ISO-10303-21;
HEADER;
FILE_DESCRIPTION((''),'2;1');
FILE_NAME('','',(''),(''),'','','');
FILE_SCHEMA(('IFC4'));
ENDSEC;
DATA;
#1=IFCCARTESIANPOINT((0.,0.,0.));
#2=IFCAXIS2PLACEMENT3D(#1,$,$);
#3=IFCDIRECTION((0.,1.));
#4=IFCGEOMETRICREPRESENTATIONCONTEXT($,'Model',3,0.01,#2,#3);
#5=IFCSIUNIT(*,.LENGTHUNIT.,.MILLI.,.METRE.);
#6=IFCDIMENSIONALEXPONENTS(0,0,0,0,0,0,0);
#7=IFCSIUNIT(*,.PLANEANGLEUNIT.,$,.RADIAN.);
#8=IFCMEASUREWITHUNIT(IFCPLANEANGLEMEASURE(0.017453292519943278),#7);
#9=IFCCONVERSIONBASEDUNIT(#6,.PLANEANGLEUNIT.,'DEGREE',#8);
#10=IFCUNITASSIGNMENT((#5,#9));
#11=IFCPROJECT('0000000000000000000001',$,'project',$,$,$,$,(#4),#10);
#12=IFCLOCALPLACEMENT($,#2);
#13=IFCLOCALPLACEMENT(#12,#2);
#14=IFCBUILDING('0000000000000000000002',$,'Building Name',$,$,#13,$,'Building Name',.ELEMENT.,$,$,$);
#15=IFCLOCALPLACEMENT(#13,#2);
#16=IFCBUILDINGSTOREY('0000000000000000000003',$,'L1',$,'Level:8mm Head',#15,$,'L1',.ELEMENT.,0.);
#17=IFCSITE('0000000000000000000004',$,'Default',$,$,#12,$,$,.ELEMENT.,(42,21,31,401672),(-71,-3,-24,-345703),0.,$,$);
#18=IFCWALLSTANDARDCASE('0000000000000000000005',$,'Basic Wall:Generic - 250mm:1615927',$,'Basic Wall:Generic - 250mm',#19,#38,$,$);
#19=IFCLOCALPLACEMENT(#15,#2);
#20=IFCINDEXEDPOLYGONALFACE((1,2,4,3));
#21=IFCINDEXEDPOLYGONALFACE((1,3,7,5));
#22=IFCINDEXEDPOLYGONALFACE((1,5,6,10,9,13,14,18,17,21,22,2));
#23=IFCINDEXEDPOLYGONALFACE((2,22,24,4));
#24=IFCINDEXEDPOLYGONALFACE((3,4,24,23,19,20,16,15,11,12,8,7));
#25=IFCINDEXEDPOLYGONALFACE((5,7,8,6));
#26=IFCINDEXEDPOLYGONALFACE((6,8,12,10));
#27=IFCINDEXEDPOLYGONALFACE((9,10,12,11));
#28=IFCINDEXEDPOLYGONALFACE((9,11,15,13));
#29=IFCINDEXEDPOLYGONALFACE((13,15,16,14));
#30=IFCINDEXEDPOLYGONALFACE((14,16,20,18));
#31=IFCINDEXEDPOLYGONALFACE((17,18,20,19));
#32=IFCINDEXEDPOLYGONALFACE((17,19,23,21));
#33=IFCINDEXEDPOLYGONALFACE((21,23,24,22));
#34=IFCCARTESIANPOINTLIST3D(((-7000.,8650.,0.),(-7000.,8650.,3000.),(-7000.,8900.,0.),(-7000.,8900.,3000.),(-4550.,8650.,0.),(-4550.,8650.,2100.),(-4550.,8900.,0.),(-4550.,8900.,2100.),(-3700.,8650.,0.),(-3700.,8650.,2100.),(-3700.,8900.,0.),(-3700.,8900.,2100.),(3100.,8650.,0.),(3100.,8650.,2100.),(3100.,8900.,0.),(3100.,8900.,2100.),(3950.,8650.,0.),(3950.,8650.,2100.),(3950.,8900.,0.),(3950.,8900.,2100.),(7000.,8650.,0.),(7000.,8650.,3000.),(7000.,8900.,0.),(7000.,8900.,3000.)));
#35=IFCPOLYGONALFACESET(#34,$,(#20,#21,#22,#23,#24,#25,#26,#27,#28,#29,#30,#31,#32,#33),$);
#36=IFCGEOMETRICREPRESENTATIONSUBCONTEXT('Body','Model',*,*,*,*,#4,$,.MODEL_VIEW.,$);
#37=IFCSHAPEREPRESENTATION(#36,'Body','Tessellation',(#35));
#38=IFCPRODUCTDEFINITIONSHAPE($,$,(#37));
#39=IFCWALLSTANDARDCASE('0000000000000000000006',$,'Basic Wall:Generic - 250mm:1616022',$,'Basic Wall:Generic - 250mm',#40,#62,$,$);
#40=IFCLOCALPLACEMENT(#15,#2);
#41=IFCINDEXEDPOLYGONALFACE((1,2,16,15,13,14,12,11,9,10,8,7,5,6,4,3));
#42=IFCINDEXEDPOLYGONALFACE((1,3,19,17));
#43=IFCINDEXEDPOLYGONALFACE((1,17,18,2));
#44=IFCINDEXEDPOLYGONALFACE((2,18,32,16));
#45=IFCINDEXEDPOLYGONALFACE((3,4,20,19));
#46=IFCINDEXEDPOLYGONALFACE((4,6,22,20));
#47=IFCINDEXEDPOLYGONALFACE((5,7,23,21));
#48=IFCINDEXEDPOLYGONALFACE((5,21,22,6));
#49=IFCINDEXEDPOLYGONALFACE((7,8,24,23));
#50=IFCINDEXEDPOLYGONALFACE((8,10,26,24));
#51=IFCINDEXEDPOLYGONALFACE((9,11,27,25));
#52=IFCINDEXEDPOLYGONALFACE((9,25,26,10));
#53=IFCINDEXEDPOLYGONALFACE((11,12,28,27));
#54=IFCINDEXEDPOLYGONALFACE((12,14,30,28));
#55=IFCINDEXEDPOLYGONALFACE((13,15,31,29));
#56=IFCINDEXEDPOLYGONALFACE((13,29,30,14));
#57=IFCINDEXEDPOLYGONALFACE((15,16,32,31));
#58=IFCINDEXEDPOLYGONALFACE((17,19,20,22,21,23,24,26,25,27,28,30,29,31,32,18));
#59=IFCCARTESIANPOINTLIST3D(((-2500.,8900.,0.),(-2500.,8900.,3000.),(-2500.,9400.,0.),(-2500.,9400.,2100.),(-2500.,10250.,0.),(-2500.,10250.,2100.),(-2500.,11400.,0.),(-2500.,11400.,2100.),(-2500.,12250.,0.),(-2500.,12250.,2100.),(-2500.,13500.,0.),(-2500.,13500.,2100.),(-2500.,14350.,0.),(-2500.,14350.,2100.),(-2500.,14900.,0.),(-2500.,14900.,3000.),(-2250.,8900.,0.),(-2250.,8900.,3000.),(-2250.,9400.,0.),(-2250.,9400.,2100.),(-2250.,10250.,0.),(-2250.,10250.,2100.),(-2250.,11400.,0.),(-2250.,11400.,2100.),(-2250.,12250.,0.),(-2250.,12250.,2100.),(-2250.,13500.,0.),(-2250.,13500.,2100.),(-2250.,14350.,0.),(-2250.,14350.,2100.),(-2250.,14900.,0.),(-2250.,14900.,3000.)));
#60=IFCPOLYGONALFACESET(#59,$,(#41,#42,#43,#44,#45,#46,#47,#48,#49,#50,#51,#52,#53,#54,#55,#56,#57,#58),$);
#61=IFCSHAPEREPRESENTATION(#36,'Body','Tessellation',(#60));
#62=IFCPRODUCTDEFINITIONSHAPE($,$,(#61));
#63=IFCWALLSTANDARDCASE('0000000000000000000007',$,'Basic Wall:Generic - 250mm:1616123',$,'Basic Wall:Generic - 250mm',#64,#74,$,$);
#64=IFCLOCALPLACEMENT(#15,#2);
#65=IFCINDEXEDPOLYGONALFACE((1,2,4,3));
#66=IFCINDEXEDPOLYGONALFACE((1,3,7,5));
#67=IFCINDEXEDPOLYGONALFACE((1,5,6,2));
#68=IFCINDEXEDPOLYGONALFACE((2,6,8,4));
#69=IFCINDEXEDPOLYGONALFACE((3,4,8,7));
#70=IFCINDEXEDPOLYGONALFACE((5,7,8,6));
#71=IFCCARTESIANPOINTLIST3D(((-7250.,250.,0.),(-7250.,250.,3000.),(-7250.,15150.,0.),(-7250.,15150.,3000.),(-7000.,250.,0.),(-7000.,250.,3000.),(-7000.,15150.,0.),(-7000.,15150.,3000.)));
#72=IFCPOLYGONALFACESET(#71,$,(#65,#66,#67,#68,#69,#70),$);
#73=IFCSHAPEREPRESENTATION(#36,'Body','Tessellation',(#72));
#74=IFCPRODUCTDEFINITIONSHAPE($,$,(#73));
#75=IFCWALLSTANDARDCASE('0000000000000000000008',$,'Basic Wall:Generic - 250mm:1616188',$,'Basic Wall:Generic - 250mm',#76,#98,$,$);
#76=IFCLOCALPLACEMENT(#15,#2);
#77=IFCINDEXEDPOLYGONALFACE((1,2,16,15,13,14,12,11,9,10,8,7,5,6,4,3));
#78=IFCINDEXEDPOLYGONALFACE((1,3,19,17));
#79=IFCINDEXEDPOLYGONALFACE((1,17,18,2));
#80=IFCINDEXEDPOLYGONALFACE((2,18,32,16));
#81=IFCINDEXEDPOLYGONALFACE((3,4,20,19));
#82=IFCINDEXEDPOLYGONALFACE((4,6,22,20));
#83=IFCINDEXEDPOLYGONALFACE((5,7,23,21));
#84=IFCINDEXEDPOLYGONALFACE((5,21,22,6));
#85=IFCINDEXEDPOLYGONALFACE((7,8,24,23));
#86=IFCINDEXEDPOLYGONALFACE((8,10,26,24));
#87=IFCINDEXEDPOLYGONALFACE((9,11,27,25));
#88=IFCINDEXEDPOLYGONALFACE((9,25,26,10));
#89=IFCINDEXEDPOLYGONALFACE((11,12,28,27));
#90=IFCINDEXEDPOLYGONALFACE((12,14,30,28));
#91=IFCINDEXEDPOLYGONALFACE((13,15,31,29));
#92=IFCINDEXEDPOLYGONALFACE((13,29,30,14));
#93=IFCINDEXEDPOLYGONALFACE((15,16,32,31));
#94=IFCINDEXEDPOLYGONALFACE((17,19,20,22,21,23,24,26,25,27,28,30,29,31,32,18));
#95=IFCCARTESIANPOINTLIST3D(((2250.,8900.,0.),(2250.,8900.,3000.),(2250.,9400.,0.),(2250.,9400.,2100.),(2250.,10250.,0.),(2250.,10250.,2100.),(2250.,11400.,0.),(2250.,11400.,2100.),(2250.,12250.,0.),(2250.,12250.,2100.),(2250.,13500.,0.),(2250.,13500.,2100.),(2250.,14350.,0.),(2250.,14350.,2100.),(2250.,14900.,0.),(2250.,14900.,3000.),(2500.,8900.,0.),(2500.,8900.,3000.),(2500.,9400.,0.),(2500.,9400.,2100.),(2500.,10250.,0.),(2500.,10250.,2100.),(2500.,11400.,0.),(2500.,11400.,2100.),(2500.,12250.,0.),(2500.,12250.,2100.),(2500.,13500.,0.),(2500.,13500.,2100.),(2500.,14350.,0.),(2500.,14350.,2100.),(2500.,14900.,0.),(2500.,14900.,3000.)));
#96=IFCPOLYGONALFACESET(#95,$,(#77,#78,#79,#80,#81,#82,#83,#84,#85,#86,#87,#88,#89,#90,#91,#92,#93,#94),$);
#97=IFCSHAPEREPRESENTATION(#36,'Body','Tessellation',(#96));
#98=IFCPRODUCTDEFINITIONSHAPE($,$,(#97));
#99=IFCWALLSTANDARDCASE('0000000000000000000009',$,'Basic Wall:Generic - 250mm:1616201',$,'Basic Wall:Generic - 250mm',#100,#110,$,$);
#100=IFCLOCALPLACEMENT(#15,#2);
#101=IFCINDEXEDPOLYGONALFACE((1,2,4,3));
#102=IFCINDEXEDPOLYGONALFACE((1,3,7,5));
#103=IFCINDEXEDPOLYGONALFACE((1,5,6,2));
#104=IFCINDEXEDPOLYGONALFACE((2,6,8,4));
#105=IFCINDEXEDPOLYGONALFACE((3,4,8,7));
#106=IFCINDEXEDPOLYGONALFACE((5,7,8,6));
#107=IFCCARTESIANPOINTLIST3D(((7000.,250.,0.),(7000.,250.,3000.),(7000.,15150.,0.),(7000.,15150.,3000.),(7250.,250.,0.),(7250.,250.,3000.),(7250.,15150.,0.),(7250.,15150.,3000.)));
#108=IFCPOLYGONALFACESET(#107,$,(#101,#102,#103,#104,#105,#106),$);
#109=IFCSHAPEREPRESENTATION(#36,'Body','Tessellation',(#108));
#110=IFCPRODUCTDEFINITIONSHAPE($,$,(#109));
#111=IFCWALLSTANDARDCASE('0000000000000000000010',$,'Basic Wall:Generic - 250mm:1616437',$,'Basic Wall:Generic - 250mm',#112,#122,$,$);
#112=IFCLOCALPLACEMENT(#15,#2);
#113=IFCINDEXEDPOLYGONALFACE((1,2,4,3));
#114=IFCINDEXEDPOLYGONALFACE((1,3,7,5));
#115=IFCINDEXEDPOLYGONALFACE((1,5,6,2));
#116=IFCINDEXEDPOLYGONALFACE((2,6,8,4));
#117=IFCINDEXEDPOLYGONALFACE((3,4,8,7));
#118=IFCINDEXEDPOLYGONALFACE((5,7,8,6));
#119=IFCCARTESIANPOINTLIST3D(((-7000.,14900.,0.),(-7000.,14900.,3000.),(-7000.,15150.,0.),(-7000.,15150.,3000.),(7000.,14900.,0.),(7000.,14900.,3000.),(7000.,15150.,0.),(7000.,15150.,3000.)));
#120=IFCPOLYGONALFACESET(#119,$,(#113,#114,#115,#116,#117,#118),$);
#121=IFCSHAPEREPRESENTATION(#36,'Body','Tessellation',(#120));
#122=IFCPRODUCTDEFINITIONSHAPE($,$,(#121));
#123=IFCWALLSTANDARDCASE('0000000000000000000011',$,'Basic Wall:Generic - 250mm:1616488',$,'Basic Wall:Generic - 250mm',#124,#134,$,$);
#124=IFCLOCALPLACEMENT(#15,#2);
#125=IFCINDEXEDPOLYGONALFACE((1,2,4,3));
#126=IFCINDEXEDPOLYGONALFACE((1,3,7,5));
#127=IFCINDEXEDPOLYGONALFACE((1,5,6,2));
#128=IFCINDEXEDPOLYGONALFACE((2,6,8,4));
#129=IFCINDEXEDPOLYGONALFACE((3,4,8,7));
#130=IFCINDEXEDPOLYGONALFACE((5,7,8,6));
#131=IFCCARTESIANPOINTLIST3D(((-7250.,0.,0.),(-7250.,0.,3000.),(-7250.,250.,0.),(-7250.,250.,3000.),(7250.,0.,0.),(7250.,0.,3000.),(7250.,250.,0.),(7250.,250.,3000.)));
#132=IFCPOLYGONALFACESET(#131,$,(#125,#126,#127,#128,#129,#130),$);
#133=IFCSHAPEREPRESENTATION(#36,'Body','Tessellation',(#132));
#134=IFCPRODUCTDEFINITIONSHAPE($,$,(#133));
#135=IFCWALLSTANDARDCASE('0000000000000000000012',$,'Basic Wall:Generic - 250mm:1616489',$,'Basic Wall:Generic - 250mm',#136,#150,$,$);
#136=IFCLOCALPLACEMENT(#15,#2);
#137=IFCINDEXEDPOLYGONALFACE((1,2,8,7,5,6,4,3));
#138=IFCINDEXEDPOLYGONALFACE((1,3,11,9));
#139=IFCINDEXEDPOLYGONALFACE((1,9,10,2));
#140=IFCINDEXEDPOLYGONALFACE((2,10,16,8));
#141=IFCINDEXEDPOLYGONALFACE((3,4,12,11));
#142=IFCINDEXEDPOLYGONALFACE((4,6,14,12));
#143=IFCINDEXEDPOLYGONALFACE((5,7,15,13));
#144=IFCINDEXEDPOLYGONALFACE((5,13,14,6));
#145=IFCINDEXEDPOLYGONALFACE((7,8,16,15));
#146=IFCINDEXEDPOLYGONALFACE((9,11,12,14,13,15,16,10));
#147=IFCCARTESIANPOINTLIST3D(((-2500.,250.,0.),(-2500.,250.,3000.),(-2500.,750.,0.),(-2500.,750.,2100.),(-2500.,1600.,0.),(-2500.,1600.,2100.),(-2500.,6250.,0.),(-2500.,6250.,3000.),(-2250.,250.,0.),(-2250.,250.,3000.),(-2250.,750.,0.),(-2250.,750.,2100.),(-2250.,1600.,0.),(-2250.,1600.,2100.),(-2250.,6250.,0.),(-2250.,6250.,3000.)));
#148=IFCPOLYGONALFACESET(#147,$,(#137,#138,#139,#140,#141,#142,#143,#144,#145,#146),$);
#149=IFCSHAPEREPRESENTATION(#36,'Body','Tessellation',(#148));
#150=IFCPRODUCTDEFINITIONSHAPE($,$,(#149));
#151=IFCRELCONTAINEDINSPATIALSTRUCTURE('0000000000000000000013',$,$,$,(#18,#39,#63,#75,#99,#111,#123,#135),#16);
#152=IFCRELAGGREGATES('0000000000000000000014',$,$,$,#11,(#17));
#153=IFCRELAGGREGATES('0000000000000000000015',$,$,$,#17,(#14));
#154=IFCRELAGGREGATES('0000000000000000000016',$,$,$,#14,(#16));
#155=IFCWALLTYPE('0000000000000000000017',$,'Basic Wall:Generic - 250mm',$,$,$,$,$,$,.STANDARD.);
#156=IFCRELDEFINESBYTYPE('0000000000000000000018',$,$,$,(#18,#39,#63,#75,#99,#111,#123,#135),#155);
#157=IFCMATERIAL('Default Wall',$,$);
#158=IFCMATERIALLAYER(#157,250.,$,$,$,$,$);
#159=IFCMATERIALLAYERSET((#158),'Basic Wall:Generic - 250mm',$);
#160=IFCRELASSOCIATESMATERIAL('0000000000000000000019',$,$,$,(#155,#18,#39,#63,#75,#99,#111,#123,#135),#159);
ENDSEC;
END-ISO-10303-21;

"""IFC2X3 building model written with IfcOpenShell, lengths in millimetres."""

from ifc_helpers import new_model, entity, si_unit, converted_unit, direction, frame, frame_2d, origin, place, context, subcontext, project, spatial, rectangle, extrude, material, layer, layer_set, layer_usage, type_object, element, save


model = new_model("IFC2X3")

# Units and contexts
model_context = context("Model", 3, precision=0.01, world=origin(), true_north=direction((0.0, 1.0)))
body_context = subcontext(model_context, "Body", "Model", "MODEL_VIEW")
ifc_project = project(units=[si_unit("LENGTHUNIT", "METRE", prefix="MILLI"), converted_unit("PLANEANGLEUNIT", "DEGREE", entity("IfcPlaneAngleMeasure", 0.017453292519943278), si_unit("PLANEANGLEUNIT", "RADIAN"), dimensions=[0, 0, 0, 0, 0, 0, 0])], contexts=[model_context])

# Site, building, storey
site_placement = place(None, origin())
site = spatial("IfcSite", under=ifc_project, at=site_placement, Name="Default", CompositionType="ELEMENT", RefLatitude=(42, 21, 31, 401672), RefLongitude=(-71, -3, -24, -345703), RefElevation=0.0)
building_placement = place(site_placement, origin())
building = spatial("IfcBuilding", under=site, at=building_placement, Name="Building Name", LongName="Building Name", CompositionType="ELEMENT")
storey_placement = place(building_placement, origin())
storey = spatial("IfcBuildingStorey", under=building, at=storey_placement, Name="L1", ObjectType="Level:8mm Head", LongName="L1", CompositionType="ELEMENT", Elevation=0.0)

# Walls, openings
ifc_material = material(Name="Default Wall")
ifc_layer_1 = layer(ifc_material, 250.0)
ifc_layer_set_1 = layer_set([ifc_layer_1], Name="Basic Wall:Generic - 250mm")
ifc_layer_usage_1 = layer_usage(ifc_layer_set_1, "AXIS2", "NEGATIVE", 125.0)
wall_type_1 = type_object("IfcWallType", Name="Basic Wall:Generic - 250mm", PredefinedType="STANDARD", material=ifc_layer_set_1)
wall_1_placement = place(storey_placement, frame((-7000.0, 8775.0, 0.0)))
wall_1 = element("IfcWallStandardCase", 1, at=wall_1_placement, inside=storey, type_object=wall_type_1, material=ifc_layer_usage_1, Name="Basic Wall:Generic - 250mm:1615927", ObjectType="Basic Wall:Generic - 250mm", context=body_context, shape_type="SweptSolid", body=[
    extrude(rectangle(XDim=14000.0, YDim=250.0, at=frame_2d((7000.0, 0.0), x_axis=(1.0, 0.0))), origin(), (0.0, 0.0, 1.0), 3000.0),
])
opening_1_placement = place(wall_1_placement, frame((2450.0, -125.0, 0.0)))
element("IfcOpeningElement", 2, at=opening_1_placement, cuts=wall_1, ObjectType="Opening", context=body_context, shape_type="SweptSolid", body=[
    extrude(rectangle(XDim=2100.0, YDim=850.0, at=frame_2d((1050.0, 425.0), x_axis=(1.0, 0.0))), frame((0.0, 0.0, 0.0), z_axis=(0.0, 1.0, 0.0), x_axis=(0.0, 0.0, 1.0)), (0.0, 0.0, 1.0), 250.0),
])
opening_2_placement = place(wall_1_placement, frame((10100.0, -125.0, 0.0)))
element("IfcOpeningElement", 3, at=opening_2_placement, cuts=wall_1, ObjectType="Opening", context=body_context, shape_type="SweptSolid", body=[
    extrude(rectangle(XDim=2100.0, YDim=850.0, at=frame_2d((1050.0, 425.0), x_axis=(1.0, 0.0))), frame((0.0, 0.0, 0.0), z_axis=(0.0, 1.0, 0.0), x_axis=(0.0, 0.0, 1.0)), (0.0, 0.0, 1.0), 250.0),
])
ifc_layer_usage_2 = layer_usage(ifc_layer_set_1, "AXIS2", "NEGATIVE", 125.0)
wall_2_placement = place(storey_placement, frame((-2375.0, 8900.0, 0.0), z_axis=(0.0, 0.0, 1.0), x_axis=(0.0, 1.0, 0.0)))
wall_2 = element("IfcWallStandardCase", 4, at=wall_2_placement, inside=storey, type_object=wall_type_1, material=ifc_layer_usage_2, Name="Basic Wall:Generic - 250mm:1616022", ObjectType="Basic Wall:Generic - 250mm", context=body_context, shape_type="SweptSolid", body=[
    extrude(rectangle(XDim=6000.0, YDim=250.0, at=frame_2d((3000.0, 0.0), x_axis=(1.0, 0.0))), origin(), (0.0, 0.0, 1.0), 3000.0),
])
opening_3_placement = place(wall_2_placement, frame((1350.0, 125.0, 0.0)))
element("IfcOpeningElement", 5, at=opening_3_placement, cuts=wall_2, ObjectType="Opening", context=body_context, shape_type="SweptSolid", body=[
    extrude(rectangle(XDim=2100.0, YDim=850.0, at=frame_2d((1050.0, 425.0), x_axis=(1.0, 0.0))), frame((0.0, 0.0, 0.0), z_axis=(0.0, -1.0, 0.0), x_axis=(0.0, 0.0, 1.0)), (0.0, 0.0, 1.0), 250.0),
])
opening_4_placement = place(wall_2_placement, frame((3350.0, 125.0, 0.0)))
element("IfcOpeningElement", 6, at=opening_4_placement, cuts=wall_2, ObjectType="Opening", context=body_context, shape_type="SweptSolid", body=[
    extrude(rectangle(XDim=2100.0, YDim=850.0, at=frame_2d((1050.0, 425.0), x_axis=(1.0, 0.0))), frame((0.0, 0.0, 0.0), z_axis=(0.0, -1.0, 0.0), x_axis=(0.0, 0.0, 1.0)), (0.0, 0.0, 1.0), 250.0),
])
opening_5_placement = place(wall_2_placement, frame((5450.0, 125.0, 0.0)))
element("IfcOpeningElement", 7, at=opening_5_placement, cuts=wall_2, ObjectType="Opening", context=body_context, shape_type="SweptSolid", body=[
    extrude(rectangle(XDim=2100.0, YDim=850.0, at=frame_2d((1050.0, 425.0), x_axis=(1.0, 0.0))), frame((0.0, 0.0, 0.0), z_axis=(0.0, -1.0, 0.0), x_axis=(0.0, 0.0, 1.0)), (0.0, 0.0, 1.0), 250.0),
])

# Wall
ifc_layer_usage_3 = layer_usage(ifc_layer_set_1, "AXIS2", "NEGATIVE", 125.0)
wall_3_placement = place(storey_placement, frame((-7125.0, 15150.0, 0.0), z_axis=(0.0, 0.0, 1.0), x_axis=(0.0, -1.0, 0.0)))
element("IfcWallStandardCase", 8, at=wall_3_placement, inside=storey, type_object=wall_type_1, material=ifc_layer_usage_3, Name="Basic Wall:Generic - 250mm:1616123", ObjectType="Basic Wall:Generic - 250mm", context=body_context, shape_type="SweptSolid", body=[
    extrude(rectangle(XDim=14900.0, YDim=250.0, at=frame_2d((7450.0, 0.0), x_axis=(-1.0, 0.0))), origin(), (0.0, 0.0, 1.0), 3000.0),
])

# Wall, openings
ifc_layer_usage_4 = layer_usage(ifc_layer_set_1, "AXIS2", "NEGATIVE", 125.0)
wall_4_placement = place(storey_placement, frame((2375.0, 8900.0, 0.0), z_axis=(0.0, 0.0, 1.0), x_axis=(0.0, 1.0, 0.0)))
wall_4 = element("IfcWallStandardCase", 9, at=wall_4_placement, inside=storey, type_object=wall_type_1, material=ifc_layer_usage_4, Name="Basic Wall:Generic - 250mm:1616188", ObjectType="Basic Wall:Generic - 250mm", context=body_context, shape_type="SweptSolid", body=[
    extrude(rectangle(XDim=6000.0, YDim=250.0, at=frame_2d((3000.0, 0.0), x_axis=(-1.0, 0.0))), origin(), (0.0, 0.0, 1.0), 3000.0),
])
opening_6_placement = place(wall_4_placement, frame((500.0, -125.0, 0.0)))
element("IfcOpeningElement", 10, at=opening_6_placement, cuts=wall_4, ObjectType="Opening", context=body_context, shape_type="SweptSolid", body=[
    extrude(rectangle(XDim=2100.0, YDim=850.0, at=frame_2d((1050.0, 425.0), x_axis=(1.0, 0.0))), frame((0.0, 0.0, 0.0), z_axis=(0.0, 1.0, 0.0), x_axis=(0.0, 0.0, 1.0)), (0.0, 0.0, 1.0), 250.0),
])
opening_7_placement = place(wall_4_placement, frame((2500.0, -125.0, 0.0)))
element("IfcOpeningElement", 11, at=opening_7_placement, cuts=wall_4, ObjectType="Opening", context=body_context, shape_type="SweptSolid", body=[
    extrude(rectangle(XDim=2100.0, YDim=850.0, at=frame_2d((1050.0, 425.0), x_axis=(1.0, 0.0))), frame((0.0, 0.0, 0.0), z_axis=(0.0, 1.0, 0.0), x_axis=(0.0, 0.0, 1.0)), (0.0, 0.0, 1.0), 250.0),
])
opening_8_placement = place(wall_4_placement, frame((4600.0, -125.0, 0.0)))
element("IfcOpeningElement", 12, at=opening_8_placement, cuts=wall_4, ObjectType="Opening", context=body_context, shape_type="SweptSolid", body=[
    extrude(rectangle(XDim=2100.0, YDim=850.0, at=frame_2d((1050.0, 425.0), x_axis=(1.0, 0.0))), frame((0.0, 0.0, 0.0), z_axis=(0.0, 1.0, 0.0), x_axis=(0.0, 0.0, 1.0)), (0.0, 0.0, 1.0), 250.0),
])

# Walls
ifc_layer_usage_5 = layer_usage(ifc_layer_set_1, "AXIS2", "NEGATIVE", 125.0)
wall_5_placement = place(storey_placement, frame((7125.0, 250.0, 0.0), z_axis=(0.0, 0.0, 1.0), x_axis=(0.0, 1.0, 0.0)))
element("IfcWallStandardCase", 13, at=wall_5_placement, inside=storey, type_object=wall_type_1, material=ifc_layer_usage_5, Name="Basic Wall:Generic - 250mm:1616201", ObjectType="Basic Wall:Generic - 250mm", context=body_context, shape_type="SweptSolid", body=[
    extrude(rectangle(XDim=14900.0, YDim=250.0, at=frame_2d((7450.0, 0.0), x_axis=(-1.0, 0.0))), origin(), (0.0, 0.0, 1.0), 3000.0),
])
ifc_layer_usage_6 = layer_usage(ifc_layer_set_1, "AXIS2", "NEGATIVE", 125.0)
wall_6_placement = place(storey_placement, frame((-7000.0, 15025.0, 0.0)))
element("IfcWallStandardCase", 14, at=wall_6_placement, inside=storey, type_object=wall_type_1, material=ifc_layer_usage_6, Name="Basic Wall:Generic - 250mm:1616437", ObjectType="Basic Wall:Generic - 250mm", context=body_context, shape_type="SweptSolid", body=[
    extrude(rectangle(XDim=14000.0, YDim=250.0, at=frame_2d((7000.0, 0.0), x_axis=(-1.0, 0.0))), origin(), (0.0, 0.0, 1.0), 3000.0),
])
ifc_layer_usage_7 = layer_usage(ifc_layer_set_1, "AXIS2", "NEGATIVE", 125.0)
wall_7_placement = place(storey_placement, frame((-7250.0, 125.0, 0.0)))
element("IfcWallStandardCase", 15, at=wall_7_placement, inside=storey, type_object=wall_type_1, material=ifc_layer_usage_7, Name="Basic Wall:Generic - 250mm:1616488", ObjectType="Basic Wall:Generic - 250mm", context=body_context, shape_type="SweptSolid", body=[
    extrude(rectangle(XDim=14500.0, YDim=250.0, at=frame_2d((7250.0, 0.0), x_axis=(-1.0, 0.0))), origin(), (0.0, 0.0, 1.0), 3000.0),
])

# Wall, opening
ifc_layer_usage_8 = layer_usage(ifc_layer_set_1, "AXIS2", "NEGATIVE", 125.0)
wall_8_placement = place(storey_placement, frame((-2375.0, 250.0, 0.0), z_axis=(0.0, 0.0, 1.0), x_axis=(0.0, 1.0, 0.0)))
wall_8 = element("IfcWallStandardCase", 16, at=wall_8_placement, inside=storey, type_object=wall_type_1, material=ifc_layer_usage_8, Name="Basic Wall:Generic - 250mm:1616489", ObjectType="Basic Wall:Generic - 250mm", context=body_context, shape_type="SweptSolid", body=[
    extrude(rectangle(XDim=6000.0, YDim=250.0, at=frame_2d((3000.0, 0.0), x_axis=(1.0, 0.0))), origin(), (0.0, 0.0, 1.0), 3000.0),
])
opening_9_placement = place(wall_8_placement, frame((1350.0, 125.0, 0.0)))
element("IfcOpeningElement", 17, at=opening_9_placement, cuts=wall_8, ObjectType="Opening", context=body_context, shape_type="SweptSolid", body=[
    extrude(rectangle(XDim=2100.0, YDim=850.0, at=frame_2d((1050.0, 425.0), x_axis=(1.0, 0.0))), frame((0.0, 0.0, 0.0), z_axis=(0.0, -1.0, 0.0), x_axis=(0.0, 0.0, 1.0)), (0.0, 0.0, 1.0), 250.0),
])

save(model, "model.ifc")
